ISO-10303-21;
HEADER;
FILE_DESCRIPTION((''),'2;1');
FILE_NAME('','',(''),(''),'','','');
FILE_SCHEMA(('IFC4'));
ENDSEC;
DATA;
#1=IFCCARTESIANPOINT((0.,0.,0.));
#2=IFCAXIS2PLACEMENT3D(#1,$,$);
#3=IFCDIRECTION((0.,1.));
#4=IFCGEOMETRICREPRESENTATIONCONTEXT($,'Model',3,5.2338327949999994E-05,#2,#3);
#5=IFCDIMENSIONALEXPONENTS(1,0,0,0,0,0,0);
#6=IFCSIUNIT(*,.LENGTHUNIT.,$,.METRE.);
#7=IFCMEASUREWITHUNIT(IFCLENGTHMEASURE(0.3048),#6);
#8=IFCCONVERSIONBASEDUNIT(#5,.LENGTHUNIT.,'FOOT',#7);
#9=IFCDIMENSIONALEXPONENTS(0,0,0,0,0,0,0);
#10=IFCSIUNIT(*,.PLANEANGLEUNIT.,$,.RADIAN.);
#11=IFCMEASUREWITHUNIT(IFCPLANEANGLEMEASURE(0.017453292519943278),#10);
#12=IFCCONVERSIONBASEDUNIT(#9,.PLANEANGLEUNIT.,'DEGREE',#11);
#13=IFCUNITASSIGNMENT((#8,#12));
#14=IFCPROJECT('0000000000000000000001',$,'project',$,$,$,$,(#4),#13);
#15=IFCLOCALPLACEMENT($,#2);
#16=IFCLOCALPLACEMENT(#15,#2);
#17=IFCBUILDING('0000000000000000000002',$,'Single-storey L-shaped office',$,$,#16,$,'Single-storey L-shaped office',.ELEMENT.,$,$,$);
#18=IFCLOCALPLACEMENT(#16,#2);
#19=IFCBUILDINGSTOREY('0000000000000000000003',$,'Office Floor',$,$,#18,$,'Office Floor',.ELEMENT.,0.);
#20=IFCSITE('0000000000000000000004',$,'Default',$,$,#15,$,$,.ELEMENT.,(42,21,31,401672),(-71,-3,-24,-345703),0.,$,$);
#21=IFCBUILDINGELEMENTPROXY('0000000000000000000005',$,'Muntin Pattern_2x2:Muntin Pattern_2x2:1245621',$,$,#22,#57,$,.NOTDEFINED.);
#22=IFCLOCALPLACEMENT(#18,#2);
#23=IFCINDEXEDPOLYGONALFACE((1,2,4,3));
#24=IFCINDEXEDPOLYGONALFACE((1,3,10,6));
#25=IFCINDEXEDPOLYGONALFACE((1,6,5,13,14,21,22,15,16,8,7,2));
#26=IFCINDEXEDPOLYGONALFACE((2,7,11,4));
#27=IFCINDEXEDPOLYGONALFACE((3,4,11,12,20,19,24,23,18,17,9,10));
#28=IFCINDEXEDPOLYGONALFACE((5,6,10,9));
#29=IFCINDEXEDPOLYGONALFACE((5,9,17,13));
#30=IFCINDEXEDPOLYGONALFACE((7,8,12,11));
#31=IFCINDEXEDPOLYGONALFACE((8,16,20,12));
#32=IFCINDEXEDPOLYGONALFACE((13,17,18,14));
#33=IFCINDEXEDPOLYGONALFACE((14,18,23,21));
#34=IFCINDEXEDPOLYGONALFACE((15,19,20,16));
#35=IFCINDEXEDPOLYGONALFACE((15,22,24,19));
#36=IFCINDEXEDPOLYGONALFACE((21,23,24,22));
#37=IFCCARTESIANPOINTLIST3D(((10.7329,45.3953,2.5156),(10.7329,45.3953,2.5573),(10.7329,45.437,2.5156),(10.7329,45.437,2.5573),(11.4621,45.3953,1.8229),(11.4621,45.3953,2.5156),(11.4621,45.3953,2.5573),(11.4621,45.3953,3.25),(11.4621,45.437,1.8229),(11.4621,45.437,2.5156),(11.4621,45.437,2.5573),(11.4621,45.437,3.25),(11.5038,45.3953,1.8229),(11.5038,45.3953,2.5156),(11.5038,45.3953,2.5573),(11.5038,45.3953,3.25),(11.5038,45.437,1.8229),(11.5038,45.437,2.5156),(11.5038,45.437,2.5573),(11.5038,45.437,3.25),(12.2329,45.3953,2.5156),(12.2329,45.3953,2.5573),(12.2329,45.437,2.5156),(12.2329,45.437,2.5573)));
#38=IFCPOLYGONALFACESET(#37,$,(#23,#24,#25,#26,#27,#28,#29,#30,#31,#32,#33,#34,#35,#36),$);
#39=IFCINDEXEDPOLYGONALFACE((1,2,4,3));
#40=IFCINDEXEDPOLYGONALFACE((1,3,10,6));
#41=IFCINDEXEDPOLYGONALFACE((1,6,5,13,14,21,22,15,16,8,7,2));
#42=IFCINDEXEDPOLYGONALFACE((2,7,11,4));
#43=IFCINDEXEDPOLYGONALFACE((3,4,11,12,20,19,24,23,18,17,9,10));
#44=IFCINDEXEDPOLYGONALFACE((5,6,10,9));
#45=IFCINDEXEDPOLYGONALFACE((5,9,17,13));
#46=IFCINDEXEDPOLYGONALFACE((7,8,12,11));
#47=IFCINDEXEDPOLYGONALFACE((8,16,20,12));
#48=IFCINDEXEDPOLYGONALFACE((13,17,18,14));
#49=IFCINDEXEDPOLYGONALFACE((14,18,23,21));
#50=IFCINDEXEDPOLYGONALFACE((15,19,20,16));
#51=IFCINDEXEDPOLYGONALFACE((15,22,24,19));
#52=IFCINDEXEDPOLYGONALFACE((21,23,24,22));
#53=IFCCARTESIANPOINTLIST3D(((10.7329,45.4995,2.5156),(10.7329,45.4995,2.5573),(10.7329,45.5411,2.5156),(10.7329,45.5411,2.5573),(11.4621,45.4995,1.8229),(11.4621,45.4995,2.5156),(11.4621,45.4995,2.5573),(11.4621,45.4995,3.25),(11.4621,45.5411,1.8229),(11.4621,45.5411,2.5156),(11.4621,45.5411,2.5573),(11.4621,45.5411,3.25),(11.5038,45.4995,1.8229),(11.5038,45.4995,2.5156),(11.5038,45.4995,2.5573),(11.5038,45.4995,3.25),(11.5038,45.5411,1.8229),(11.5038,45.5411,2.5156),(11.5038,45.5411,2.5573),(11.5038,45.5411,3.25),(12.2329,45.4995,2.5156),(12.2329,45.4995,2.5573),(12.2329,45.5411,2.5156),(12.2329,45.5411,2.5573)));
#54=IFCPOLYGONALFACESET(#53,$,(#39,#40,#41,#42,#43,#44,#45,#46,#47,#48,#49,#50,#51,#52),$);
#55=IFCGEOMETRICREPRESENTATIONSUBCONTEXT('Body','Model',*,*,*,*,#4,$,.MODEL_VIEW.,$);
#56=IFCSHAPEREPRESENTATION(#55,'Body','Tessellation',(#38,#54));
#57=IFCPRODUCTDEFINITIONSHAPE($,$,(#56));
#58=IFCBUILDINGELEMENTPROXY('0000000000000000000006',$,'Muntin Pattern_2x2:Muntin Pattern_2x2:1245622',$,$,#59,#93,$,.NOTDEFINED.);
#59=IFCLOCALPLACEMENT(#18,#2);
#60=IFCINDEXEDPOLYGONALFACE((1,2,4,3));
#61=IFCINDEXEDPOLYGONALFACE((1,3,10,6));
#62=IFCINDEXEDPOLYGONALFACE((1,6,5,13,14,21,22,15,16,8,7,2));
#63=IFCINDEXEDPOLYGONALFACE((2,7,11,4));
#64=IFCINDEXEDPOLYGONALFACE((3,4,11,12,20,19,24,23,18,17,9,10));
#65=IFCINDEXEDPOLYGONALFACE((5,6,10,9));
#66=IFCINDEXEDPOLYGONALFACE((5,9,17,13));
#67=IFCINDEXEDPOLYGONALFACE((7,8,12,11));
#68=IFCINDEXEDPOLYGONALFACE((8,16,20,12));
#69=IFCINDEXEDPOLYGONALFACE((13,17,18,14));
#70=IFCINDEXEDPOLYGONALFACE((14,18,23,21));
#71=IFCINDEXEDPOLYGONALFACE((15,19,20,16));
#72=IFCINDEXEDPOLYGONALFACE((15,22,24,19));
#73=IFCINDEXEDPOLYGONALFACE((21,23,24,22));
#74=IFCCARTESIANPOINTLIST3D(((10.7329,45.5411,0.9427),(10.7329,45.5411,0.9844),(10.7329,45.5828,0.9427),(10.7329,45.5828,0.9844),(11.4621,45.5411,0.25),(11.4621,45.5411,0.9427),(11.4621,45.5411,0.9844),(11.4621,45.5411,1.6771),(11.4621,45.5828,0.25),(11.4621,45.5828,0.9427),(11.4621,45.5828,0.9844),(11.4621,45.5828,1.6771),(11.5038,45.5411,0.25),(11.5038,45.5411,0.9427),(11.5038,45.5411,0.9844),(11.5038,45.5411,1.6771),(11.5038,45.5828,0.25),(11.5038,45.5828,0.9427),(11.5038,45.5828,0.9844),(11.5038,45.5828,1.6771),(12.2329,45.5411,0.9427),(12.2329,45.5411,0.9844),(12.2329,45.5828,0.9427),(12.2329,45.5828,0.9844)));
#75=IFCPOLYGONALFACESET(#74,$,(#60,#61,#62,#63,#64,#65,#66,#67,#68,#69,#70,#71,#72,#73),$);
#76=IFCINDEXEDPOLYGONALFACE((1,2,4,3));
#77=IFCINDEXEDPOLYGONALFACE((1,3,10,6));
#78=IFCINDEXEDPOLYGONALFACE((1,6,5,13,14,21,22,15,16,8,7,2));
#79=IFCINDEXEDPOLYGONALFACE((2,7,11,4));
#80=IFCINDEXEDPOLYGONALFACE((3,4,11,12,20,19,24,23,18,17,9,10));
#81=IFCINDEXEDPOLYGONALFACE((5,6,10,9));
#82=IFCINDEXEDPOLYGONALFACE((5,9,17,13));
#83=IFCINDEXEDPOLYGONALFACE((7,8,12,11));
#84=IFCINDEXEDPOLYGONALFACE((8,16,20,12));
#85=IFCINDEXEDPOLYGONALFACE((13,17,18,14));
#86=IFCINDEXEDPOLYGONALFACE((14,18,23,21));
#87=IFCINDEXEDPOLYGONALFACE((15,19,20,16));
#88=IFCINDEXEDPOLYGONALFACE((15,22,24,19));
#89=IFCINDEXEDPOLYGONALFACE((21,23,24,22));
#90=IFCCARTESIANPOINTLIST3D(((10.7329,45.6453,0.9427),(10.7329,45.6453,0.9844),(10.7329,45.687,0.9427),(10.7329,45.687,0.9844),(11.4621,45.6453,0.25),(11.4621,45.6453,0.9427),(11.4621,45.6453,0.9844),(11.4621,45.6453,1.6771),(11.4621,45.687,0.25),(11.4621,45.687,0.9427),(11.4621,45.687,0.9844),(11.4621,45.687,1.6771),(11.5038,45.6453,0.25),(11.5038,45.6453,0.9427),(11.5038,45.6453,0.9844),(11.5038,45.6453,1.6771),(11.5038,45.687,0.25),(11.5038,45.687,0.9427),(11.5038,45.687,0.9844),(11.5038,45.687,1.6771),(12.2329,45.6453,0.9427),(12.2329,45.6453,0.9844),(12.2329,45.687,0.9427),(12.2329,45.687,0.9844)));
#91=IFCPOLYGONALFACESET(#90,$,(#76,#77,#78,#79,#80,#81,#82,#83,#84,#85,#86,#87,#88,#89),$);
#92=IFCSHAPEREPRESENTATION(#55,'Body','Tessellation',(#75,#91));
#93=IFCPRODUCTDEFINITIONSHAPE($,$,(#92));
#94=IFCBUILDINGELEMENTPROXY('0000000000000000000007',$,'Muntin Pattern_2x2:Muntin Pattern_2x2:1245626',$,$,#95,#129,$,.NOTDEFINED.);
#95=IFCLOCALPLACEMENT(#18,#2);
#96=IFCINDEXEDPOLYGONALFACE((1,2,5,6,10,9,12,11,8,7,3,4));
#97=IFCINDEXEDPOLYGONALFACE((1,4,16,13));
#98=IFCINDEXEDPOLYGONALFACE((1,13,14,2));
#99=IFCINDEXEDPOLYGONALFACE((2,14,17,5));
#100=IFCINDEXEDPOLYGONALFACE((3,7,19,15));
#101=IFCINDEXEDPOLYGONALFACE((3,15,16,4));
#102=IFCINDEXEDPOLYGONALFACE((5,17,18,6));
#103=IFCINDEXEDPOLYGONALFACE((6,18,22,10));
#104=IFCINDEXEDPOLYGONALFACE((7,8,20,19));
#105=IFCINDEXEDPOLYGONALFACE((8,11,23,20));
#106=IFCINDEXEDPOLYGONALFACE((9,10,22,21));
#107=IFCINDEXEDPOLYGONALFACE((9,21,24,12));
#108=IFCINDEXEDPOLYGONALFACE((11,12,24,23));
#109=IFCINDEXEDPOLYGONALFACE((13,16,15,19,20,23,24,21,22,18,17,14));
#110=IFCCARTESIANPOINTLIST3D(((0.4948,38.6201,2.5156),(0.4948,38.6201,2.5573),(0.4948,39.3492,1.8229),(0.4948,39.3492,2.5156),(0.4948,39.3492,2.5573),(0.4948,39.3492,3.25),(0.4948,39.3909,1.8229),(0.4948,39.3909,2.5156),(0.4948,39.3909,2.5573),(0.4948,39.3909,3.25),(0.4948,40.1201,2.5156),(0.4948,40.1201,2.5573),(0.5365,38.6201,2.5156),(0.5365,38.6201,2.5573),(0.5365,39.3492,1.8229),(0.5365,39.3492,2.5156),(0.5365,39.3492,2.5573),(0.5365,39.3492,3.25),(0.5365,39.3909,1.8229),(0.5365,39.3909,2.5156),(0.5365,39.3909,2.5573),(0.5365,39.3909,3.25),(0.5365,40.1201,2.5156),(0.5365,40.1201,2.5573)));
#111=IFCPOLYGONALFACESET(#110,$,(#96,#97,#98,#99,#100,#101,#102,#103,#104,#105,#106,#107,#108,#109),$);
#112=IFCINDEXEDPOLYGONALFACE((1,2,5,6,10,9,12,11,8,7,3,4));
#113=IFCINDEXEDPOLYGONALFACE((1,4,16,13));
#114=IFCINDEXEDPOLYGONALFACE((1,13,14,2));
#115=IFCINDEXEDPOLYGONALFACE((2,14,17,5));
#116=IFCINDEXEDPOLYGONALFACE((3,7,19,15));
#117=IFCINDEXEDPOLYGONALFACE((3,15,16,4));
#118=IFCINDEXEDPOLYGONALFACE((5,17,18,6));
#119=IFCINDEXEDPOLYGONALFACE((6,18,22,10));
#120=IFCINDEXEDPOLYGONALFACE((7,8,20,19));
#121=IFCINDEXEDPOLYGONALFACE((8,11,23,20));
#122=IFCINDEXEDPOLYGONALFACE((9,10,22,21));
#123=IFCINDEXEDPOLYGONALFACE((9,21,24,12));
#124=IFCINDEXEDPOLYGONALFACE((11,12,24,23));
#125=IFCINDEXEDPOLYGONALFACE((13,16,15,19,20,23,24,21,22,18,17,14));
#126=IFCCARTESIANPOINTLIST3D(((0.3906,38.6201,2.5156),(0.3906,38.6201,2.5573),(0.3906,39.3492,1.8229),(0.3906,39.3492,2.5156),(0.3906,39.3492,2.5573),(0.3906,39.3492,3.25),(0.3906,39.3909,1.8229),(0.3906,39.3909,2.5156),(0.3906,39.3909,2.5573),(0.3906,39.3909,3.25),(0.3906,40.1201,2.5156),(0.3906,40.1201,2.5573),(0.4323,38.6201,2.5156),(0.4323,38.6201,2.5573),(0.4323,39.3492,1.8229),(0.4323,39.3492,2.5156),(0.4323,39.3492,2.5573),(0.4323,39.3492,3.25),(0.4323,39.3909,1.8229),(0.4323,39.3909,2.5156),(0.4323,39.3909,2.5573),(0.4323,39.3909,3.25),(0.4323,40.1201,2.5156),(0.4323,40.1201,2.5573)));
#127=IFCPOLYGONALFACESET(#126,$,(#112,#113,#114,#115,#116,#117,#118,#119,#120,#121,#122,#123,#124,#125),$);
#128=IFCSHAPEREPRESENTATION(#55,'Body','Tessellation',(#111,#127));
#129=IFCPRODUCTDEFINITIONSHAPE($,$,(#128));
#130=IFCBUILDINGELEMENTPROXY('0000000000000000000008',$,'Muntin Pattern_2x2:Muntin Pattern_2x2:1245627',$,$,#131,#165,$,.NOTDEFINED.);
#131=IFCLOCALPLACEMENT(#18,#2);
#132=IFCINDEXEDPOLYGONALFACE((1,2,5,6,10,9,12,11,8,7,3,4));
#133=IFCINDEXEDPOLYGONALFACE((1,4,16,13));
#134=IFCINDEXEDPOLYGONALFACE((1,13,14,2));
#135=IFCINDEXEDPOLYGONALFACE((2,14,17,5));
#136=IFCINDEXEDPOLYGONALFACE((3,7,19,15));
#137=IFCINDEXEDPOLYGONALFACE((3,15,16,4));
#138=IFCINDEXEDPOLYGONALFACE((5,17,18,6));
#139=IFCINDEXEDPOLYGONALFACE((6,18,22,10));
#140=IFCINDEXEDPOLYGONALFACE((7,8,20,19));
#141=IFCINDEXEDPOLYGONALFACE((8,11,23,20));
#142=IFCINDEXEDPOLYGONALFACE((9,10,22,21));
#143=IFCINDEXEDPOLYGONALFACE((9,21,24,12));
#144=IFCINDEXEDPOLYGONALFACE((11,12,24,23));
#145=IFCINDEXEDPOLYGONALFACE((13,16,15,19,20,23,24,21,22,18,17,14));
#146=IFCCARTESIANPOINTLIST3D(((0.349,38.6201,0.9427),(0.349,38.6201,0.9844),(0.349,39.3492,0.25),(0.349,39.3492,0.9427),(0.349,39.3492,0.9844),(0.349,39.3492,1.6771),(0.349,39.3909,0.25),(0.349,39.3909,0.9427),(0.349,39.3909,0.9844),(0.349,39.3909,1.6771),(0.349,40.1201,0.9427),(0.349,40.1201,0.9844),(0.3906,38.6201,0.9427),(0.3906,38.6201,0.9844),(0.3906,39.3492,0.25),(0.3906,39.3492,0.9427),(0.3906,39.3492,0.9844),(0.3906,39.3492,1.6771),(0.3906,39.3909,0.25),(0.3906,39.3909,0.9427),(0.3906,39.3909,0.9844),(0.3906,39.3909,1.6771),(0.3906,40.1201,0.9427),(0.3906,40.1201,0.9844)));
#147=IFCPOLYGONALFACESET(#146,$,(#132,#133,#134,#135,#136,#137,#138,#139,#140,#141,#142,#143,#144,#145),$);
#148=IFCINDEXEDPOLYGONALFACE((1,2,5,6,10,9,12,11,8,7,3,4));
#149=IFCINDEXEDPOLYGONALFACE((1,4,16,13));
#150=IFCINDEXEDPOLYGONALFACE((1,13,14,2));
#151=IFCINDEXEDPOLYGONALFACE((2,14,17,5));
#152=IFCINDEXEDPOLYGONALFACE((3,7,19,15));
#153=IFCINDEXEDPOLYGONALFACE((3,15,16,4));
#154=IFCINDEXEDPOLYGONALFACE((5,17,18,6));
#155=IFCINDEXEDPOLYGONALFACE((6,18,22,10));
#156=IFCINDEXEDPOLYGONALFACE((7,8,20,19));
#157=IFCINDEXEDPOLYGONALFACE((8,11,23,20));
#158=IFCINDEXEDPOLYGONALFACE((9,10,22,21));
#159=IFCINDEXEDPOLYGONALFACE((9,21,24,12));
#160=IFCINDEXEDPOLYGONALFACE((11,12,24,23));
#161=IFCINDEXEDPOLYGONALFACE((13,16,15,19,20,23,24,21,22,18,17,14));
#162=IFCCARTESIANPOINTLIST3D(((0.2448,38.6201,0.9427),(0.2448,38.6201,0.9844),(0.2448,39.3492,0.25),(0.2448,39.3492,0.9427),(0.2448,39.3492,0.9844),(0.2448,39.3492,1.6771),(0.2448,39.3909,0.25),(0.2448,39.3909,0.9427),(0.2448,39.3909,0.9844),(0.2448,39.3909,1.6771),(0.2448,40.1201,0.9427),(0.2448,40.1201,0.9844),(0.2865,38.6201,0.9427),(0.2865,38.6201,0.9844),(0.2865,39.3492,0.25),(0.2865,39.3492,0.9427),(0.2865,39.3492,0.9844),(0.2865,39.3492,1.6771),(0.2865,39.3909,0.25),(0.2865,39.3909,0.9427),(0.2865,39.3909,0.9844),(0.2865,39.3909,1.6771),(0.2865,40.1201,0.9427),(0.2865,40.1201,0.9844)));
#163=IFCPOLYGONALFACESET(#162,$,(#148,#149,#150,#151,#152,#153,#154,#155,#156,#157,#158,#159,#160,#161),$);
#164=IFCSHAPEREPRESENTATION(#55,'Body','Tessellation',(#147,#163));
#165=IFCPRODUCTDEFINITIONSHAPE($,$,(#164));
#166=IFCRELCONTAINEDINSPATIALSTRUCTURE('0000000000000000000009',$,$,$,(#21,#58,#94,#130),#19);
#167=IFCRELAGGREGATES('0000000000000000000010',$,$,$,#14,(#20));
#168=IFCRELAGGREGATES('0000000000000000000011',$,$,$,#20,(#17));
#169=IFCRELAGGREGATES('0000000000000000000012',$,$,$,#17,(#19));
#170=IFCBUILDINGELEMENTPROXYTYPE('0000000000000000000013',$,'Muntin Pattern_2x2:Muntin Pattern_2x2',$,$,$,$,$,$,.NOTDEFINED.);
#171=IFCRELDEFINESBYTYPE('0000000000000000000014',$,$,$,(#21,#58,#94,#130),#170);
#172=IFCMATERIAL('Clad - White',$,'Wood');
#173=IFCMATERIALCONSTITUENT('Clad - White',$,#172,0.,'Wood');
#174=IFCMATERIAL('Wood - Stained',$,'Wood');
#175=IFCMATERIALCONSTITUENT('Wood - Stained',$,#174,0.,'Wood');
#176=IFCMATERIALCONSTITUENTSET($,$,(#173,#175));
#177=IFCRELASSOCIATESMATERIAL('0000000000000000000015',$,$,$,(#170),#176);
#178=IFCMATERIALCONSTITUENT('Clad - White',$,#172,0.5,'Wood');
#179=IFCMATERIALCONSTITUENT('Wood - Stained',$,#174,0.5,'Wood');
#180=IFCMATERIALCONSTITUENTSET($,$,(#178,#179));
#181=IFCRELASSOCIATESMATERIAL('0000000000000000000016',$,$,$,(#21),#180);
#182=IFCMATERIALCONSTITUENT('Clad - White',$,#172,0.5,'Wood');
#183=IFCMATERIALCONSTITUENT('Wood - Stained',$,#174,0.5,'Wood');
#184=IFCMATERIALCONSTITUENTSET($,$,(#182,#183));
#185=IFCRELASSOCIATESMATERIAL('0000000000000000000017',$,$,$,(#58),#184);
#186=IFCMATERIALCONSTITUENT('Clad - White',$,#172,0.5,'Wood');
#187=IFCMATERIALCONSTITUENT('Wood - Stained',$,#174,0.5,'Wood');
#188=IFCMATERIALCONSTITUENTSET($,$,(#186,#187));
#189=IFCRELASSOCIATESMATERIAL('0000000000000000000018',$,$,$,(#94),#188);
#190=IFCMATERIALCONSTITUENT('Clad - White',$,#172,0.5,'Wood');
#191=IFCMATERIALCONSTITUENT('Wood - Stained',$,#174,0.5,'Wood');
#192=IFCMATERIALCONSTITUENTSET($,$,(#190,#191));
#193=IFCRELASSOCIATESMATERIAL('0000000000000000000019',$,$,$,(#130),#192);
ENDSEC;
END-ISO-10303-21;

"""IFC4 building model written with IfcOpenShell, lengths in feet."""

from ifc_helpers import new_model, entity, si_unit, converted_unit, direction, frame, origin, place, context, subcontext, project, spatial, indexed_curve, outline, extrude, source, transform, mapped, material, constituent, constituent_set, type_object, type_shapes, element, save


model = new_model("IFC4")

# Units and contexts
model_context = context("Model", 3, precision=5.2338327949999994e-05, world=origin(), true_north=direction((0.0, 1.0)))
body_context = subcontext(model_context, "Body", "Model", "MODEL_VIEW")
ifc_project = project(units=[converted_unit("LENGTHUNIT", "FOOT", entity("IfcLengthMeasure", 0.3048), si_unit("LENGTHUNIT", "METRE"), dimensions=[1, 0, 0, 0, 0, 0, 0]), converted_unit("PLANEANGLEUNIT", "DEGREE", entity("IfcPlaneAngleMeasure", 0.017453292519943278), si_unit("PLANEANGLEUNIT", "RADIAN"), dimensions=[0, 0, 0, 0, 0, 0, 0])], contexts=[model_context])

# Site, building, storey
site_placement = place(None, origin())
site = spatial("IfcSite", under=ifc_project, at=site_placement, Name="Default", CompositionType="ELEMENT", RefLatitude=(42, 21, 31, 401672), RefLongitude=(-71, -3, -24, -345703), RefElevation=0.0)
building_placement = place(site_placement, origin())
building = spatial("IfcBuilding", under=site, at=building_placement, Name="Single-storey L-shaped office", LongName="Single-storey L-shaped office", CompositionType="ELEMENT")
storey_placement = place(building_placement, origin())
storey = spatial("IfcBuildingStorey", under=building, at=storey_placement, Name="Office Floor", LongName="Office Floor", CompositionType="ELEMENT", Elevation=0.0)

# Shared definitions
ifc_material_1 = material(Name="Wood - Stained", Category="Wood")

# Building element proxies
ifc_material_2 = material(Name="Clad - White", Category="Wood")
ifc_constituent_1 = constituent(ifc_material_2, Name="Clad - White", Category="Wood", fraction=0.0)
ifc_constituent_2 = constituent(ifc_material_1, Name="Wood - Stained", Category="Wood", fraction=0.0)
ifc_constituent_set_1 = constituent_set(constituents=[ifc_constituent_1, ifc_constituent_2])
building_element_proxy_type_1 = type_object("IfcBuildingElementProxyType", Name="Muntin Pattern_2x2:Muntin Pattern_2x2", PredefinedType="NOTDEFINED", material=ifc_constituent_set_1)
shared_shape_1 = source(origin(), body_context, "Body", "SweptSolid", [
    extrude(outline(indexed_curve([(0.0208, -0.0208), (0.7135, -0.0208), (0.7135, 0.0208), (0.0208, 0.0208), (0.0208, 0.75), (-0.0208, 0.75), (-0.0208, 0.0208), (-0.7135, 0.0208), (-0.7135, -0.0208), (-0.0208, -0.0208), (-0.0208, -0.75), (0.0208, -0.75), (0.0208, -0.0208)], self_intersect=False)), frame((0.0, 0.0312, 0.7135), z_axis=(0.0, 1.0, 0.0), x_axis=(0.0, 0.0, 1.0)), (0.0, 0.0, 1.0), 0.0417),
    extrude(outline(indexed_curve([(0.0208, -0.0208), (0.7135, -0.0208), (0.7135, 0.0208), (0.0208, 0.0208), (0.0208, 0.75), (-0.0208, 0.75), (-0.0208, 0.0208), (-0.7135, 0.0208), (-0.7135, -0.0208), (-0.0208, -0.0208), (-0.0208, -0.75), (0.0208, -0.75), (0.0208, -0.0208)], self_intersect=False)), frame((0.0, -0.0729, 0.7135), z_axis=(0.0, 1.0, 0.0), x_axis=(0.0, 0.0, 1.0)), (0.0, 0.0, 1.0), 0.0417),
])
type_shapes(building_element_proxy_type_1, [shared_shape_1])
ifc_constituent_3 = constituent(ifc_material_2, Name="Clad - White", Category="Wood", fraction=0.5)
ifc_constituent_4 = constituent(ifc_material_1, Name="Wood - Stained", Category="Wood", fraction=0.5)
ifc_constituent_set_2 = constituent_set(constituents=[ifc_constituent_3, ifc_constituent_4])
proxy_1_placement = place(storey_placement, frame((11.4829, 45.4682, 1.8229), z_axis=(0.0, 0.0, 1.0), x_axis=(-1.0, 0.0, 0.0)))
element("IfcBuildingElementProxy", 1, at=proxy_1_placement, inside=storey, type_object=building_element_proxy_type_1, material=ifc_constituent_set_2, Name="Muntin Pattern_2x2:Muntin Pattern_2x2:1245621", PredefinedType="NOTDEFINED", context=body_context, shape_type="MappedRepresentation", body=[
    mapped(shared_shape_1, transform((0.0, 0.0, 0.0), scale=1.0)),
])
ifc_constituent_5 = constituent(ifc_material_2, Name="Clad - White", Category="Wood", fraction=0.5)
ifc_constituent_6 = constituent(ifc_material_1, Name="Wood - Stained", Category="Wood", fraction=0.5)
ifc_constituent_set_3 = constituent_set(constituents=[ifc_constituent_5, ifc_constituent_6])
proxy_2_placement = place(storey_placement, frame((11.4829, 45.6141, 0.25), z_axis=(0.0, 0.0, 1.0), x_axis=(-1.0, 0.0, 0.0)))
element("IfcBuildingElementProxy", 2, at=proxy_2_placement, inside=storey, type_object=building_element_proxy_type_1, material=ifc_constituent_set_3, Name="Muntin Pattern_2x2:Muntin Pattern_2x2:1245622", PredefinedType="NOTDEFINED", context=body_context, shape_type="MappedRepresentation", body=[
    mapped(shared_shape_1, transform((0.0, 0.0, 0.0), scale=1.0)),
])
ifc_constituent_7 = constituent(ifc_material_2, Name="Clad - White", Category="Wood", fraction=0.5)
ifc_constituent_8 = constituent(ifc_material_1, Name="Wood - Stained", Category="Wood", fraction=0.5)
ifc_constituent_set_4 = constituent_set(constituents=[ifc_constituent_7, ifc_constituent_8])
proxy_3_placement = place(storey_placement, frame((0.4635, 39.3701, 1.8229), z_axis=(0.0, 0.0, 1.0), x_axis=(0.0, -1.0, 0.0)))
element("IfcBuildingElementProxy", 3, at=proxy_3_placement, inside=storey, type_object=building_element_proxy_type_1, material=ifc_constituent_set_4, Name="Muntin Pattern_2x2:Muntin Pattern_2x2:1245626", PredefinedType="NOTDEFINED", context=body_context, shape_type="MappedRepresentation", body=[
    mapped(shared_shape_1, transform((0.0, 0.0, 0.0), scale=1.0)),
])
ifc_constituent_9 = constituent(ifc_material_2, Name="Clad - White", Category="Wood", fraction=0.5)
ifc_constituent_10 = constituent(ifc_material_1, Name="Wood - Stained", Category="Wood", fraction=0.5)
ifc_constituent_set_5 = constituent_set(constituents=[ifc_constituent_9, ifc_constituent_10])
proxy_4_placement = place(storey_placement, frame((0.3177, 39.3701, 0.25), z_axis=(0.0, 0.0, 1.0), x_axis=(0.0, -1.0, 0.0)))
element("IfcBuildingElementProxy", 4, at=proxy_4_placement, inside=storey, type_object=building_element_proxy_type_1, material=ifc_constituent_set_5, Name="Muntin Pattern_2x2:Muntin Pattern_2x2:1245627", PredefinedType="NOTDEFINED", context=body_context, shape_type="MappedRepresentation", body=[
    mapped(shared_shape_1, transform((0.0, 0.0, 0.0), scale=1.0)),
])

save(model, "model.ifc")
